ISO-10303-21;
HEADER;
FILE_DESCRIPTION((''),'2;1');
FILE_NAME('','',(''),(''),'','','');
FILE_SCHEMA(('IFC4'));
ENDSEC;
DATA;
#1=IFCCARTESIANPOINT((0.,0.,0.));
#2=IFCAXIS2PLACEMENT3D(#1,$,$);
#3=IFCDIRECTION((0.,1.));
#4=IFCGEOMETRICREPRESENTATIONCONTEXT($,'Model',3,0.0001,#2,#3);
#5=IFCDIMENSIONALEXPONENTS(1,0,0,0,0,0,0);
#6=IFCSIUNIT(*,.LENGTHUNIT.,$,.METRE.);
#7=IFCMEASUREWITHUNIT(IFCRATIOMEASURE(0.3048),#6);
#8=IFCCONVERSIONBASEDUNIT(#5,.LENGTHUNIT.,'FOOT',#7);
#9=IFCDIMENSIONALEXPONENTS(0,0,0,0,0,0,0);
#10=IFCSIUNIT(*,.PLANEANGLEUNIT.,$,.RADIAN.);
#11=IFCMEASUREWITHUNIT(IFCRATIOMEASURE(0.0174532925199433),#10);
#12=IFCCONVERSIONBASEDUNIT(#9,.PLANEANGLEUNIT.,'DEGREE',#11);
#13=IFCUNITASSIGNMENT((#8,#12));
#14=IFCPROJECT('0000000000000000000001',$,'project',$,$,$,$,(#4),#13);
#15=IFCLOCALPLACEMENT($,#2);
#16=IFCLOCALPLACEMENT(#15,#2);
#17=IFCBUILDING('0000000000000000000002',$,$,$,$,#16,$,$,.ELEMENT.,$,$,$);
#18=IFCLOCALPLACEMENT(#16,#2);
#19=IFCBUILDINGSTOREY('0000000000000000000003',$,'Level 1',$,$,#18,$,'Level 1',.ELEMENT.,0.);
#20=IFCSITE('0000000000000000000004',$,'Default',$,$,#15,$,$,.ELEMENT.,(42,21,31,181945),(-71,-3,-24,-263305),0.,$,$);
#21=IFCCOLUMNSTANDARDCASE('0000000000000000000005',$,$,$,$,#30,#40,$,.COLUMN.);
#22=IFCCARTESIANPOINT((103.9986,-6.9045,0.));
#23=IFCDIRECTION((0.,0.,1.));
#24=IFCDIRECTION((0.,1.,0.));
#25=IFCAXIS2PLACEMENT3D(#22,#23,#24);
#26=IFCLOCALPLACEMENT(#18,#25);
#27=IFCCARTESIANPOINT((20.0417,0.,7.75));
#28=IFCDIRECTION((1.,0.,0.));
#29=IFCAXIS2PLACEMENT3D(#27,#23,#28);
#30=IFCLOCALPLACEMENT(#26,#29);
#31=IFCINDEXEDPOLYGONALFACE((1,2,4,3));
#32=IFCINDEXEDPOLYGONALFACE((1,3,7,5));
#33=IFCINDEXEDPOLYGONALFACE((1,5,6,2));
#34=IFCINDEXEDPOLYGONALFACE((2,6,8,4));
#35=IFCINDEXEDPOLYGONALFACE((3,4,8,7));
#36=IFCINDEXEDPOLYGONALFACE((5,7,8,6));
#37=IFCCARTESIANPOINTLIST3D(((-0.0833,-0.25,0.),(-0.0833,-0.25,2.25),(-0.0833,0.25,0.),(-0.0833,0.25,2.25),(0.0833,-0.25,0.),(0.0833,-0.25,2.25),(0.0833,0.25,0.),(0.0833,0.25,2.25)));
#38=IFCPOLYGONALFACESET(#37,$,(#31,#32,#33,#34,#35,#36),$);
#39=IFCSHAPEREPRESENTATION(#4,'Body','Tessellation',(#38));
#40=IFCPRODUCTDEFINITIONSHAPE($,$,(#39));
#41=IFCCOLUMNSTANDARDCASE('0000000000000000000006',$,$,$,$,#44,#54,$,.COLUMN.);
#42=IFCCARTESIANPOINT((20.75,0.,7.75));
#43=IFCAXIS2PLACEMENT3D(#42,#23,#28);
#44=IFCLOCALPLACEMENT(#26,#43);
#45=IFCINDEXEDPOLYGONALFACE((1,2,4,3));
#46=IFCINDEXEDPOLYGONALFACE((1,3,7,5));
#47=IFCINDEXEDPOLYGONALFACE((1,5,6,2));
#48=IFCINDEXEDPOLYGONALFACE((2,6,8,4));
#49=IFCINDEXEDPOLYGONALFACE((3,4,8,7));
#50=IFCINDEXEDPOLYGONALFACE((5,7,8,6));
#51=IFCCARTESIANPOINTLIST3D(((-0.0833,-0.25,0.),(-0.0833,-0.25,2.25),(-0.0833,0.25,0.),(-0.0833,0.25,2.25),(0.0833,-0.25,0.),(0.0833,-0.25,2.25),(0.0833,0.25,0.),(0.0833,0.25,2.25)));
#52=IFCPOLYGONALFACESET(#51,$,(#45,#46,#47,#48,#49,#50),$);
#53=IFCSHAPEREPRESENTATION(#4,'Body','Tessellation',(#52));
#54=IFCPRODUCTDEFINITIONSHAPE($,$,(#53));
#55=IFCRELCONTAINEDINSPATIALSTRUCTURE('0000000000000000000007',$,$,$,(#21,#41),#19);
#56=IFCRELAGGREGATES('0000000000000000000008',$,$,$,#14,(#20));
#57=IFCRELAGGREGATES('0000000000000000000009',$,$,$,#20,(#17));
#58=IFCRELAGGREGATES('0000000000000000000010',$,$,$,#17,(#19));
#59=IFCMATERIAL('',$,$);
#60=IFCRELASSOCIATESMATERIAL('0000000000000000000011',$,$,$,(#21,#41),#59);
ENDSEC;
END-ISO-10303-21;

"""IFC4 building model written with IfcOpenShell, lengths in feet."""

from ifc_helpers import new_model, entity, si_unit, converted_unit, direction, frame, origin, place, context, project, spatial, rectangle, extrude, material, element, save


model = new_model("IFC4")

# Units and contexts
model_context = context("Model", 3, precision=0.0001, world=origin(), true_north=direction((0.0, 1.0)))
ifc_project = project(units=[converted_unit("LENGTHUNIT", "FOOT", entity("IfcRatioMeasure", 0.3048), si_unit("LENGTHUNIT", "METRE"), dimensions=[1, 0, 0, 0, 0, 0, 0]), converted_unit("PLANEANGLEUNIT", "DEGREE", entity("IfcRatioMeasure", 0.0174532925199433), si_unit("PLANEANGLEUNIT", "RADIAN"), dimensions=[0, 0, 0, 0, 0, 0, 0])], contexts=[model_context])

# Site, building, storey
site_placement = place(None, origin())
site = spatial("IfcSite", under=ifc_project, at=site_placement, Name="Default", CompositionType="ELEMENT", RefLatitude=(42, 21, 31, 181945), RefLongitude=(-71, -3, -24, -263305), RefElevation=0.0)
building_placement = place(site_placement, origin())
building = spatial("IfcBuilding", under=site, at=building_placement, CompositionType="ELEMENT")
storey_placement = place(building_placement, origin())
storey = spatial("IfcBuildingStorey", under=building, at=storey_placement, Name="Level 1", LongName="Level 1", CompositionType="ELEMENT", Elevation=0.0)

# Columns
placement = place(storey_placement, frame((103.9986, -6.9045, 0.0), z_axis=(0.0, 0.0, 1.0), x_axis=(0.0, 1.0, 0.0)))
ifc_material_1 = material(Name="")
for number, where, z_axis, x_axis in (
    (1, (20.0417, 0.0, 7.75), (0.0, 0.0, 1.0), (1.0, 0.0, 0.0)),
    (2, (20.75, 0.0, 7.75), (0.0, 0.0, 1.0), (1.0, 0.0, 0.0)),
):
    element("IfcColumnStandardCase", number, at=place(placement, frame(where, z_axis=z_axis, x_axis=x_axis)), inside=storey, material=ifc_material_1, PredefinedType="COLUMN", context=model_context, shape_type="SweptSolid", body=[
        extrude(rectangle(XDim=0.1667, YDim=0.5), origin(), (0.0, 0.0, 1.0), 2.25),
    ])

save(model, "model.ifc")
